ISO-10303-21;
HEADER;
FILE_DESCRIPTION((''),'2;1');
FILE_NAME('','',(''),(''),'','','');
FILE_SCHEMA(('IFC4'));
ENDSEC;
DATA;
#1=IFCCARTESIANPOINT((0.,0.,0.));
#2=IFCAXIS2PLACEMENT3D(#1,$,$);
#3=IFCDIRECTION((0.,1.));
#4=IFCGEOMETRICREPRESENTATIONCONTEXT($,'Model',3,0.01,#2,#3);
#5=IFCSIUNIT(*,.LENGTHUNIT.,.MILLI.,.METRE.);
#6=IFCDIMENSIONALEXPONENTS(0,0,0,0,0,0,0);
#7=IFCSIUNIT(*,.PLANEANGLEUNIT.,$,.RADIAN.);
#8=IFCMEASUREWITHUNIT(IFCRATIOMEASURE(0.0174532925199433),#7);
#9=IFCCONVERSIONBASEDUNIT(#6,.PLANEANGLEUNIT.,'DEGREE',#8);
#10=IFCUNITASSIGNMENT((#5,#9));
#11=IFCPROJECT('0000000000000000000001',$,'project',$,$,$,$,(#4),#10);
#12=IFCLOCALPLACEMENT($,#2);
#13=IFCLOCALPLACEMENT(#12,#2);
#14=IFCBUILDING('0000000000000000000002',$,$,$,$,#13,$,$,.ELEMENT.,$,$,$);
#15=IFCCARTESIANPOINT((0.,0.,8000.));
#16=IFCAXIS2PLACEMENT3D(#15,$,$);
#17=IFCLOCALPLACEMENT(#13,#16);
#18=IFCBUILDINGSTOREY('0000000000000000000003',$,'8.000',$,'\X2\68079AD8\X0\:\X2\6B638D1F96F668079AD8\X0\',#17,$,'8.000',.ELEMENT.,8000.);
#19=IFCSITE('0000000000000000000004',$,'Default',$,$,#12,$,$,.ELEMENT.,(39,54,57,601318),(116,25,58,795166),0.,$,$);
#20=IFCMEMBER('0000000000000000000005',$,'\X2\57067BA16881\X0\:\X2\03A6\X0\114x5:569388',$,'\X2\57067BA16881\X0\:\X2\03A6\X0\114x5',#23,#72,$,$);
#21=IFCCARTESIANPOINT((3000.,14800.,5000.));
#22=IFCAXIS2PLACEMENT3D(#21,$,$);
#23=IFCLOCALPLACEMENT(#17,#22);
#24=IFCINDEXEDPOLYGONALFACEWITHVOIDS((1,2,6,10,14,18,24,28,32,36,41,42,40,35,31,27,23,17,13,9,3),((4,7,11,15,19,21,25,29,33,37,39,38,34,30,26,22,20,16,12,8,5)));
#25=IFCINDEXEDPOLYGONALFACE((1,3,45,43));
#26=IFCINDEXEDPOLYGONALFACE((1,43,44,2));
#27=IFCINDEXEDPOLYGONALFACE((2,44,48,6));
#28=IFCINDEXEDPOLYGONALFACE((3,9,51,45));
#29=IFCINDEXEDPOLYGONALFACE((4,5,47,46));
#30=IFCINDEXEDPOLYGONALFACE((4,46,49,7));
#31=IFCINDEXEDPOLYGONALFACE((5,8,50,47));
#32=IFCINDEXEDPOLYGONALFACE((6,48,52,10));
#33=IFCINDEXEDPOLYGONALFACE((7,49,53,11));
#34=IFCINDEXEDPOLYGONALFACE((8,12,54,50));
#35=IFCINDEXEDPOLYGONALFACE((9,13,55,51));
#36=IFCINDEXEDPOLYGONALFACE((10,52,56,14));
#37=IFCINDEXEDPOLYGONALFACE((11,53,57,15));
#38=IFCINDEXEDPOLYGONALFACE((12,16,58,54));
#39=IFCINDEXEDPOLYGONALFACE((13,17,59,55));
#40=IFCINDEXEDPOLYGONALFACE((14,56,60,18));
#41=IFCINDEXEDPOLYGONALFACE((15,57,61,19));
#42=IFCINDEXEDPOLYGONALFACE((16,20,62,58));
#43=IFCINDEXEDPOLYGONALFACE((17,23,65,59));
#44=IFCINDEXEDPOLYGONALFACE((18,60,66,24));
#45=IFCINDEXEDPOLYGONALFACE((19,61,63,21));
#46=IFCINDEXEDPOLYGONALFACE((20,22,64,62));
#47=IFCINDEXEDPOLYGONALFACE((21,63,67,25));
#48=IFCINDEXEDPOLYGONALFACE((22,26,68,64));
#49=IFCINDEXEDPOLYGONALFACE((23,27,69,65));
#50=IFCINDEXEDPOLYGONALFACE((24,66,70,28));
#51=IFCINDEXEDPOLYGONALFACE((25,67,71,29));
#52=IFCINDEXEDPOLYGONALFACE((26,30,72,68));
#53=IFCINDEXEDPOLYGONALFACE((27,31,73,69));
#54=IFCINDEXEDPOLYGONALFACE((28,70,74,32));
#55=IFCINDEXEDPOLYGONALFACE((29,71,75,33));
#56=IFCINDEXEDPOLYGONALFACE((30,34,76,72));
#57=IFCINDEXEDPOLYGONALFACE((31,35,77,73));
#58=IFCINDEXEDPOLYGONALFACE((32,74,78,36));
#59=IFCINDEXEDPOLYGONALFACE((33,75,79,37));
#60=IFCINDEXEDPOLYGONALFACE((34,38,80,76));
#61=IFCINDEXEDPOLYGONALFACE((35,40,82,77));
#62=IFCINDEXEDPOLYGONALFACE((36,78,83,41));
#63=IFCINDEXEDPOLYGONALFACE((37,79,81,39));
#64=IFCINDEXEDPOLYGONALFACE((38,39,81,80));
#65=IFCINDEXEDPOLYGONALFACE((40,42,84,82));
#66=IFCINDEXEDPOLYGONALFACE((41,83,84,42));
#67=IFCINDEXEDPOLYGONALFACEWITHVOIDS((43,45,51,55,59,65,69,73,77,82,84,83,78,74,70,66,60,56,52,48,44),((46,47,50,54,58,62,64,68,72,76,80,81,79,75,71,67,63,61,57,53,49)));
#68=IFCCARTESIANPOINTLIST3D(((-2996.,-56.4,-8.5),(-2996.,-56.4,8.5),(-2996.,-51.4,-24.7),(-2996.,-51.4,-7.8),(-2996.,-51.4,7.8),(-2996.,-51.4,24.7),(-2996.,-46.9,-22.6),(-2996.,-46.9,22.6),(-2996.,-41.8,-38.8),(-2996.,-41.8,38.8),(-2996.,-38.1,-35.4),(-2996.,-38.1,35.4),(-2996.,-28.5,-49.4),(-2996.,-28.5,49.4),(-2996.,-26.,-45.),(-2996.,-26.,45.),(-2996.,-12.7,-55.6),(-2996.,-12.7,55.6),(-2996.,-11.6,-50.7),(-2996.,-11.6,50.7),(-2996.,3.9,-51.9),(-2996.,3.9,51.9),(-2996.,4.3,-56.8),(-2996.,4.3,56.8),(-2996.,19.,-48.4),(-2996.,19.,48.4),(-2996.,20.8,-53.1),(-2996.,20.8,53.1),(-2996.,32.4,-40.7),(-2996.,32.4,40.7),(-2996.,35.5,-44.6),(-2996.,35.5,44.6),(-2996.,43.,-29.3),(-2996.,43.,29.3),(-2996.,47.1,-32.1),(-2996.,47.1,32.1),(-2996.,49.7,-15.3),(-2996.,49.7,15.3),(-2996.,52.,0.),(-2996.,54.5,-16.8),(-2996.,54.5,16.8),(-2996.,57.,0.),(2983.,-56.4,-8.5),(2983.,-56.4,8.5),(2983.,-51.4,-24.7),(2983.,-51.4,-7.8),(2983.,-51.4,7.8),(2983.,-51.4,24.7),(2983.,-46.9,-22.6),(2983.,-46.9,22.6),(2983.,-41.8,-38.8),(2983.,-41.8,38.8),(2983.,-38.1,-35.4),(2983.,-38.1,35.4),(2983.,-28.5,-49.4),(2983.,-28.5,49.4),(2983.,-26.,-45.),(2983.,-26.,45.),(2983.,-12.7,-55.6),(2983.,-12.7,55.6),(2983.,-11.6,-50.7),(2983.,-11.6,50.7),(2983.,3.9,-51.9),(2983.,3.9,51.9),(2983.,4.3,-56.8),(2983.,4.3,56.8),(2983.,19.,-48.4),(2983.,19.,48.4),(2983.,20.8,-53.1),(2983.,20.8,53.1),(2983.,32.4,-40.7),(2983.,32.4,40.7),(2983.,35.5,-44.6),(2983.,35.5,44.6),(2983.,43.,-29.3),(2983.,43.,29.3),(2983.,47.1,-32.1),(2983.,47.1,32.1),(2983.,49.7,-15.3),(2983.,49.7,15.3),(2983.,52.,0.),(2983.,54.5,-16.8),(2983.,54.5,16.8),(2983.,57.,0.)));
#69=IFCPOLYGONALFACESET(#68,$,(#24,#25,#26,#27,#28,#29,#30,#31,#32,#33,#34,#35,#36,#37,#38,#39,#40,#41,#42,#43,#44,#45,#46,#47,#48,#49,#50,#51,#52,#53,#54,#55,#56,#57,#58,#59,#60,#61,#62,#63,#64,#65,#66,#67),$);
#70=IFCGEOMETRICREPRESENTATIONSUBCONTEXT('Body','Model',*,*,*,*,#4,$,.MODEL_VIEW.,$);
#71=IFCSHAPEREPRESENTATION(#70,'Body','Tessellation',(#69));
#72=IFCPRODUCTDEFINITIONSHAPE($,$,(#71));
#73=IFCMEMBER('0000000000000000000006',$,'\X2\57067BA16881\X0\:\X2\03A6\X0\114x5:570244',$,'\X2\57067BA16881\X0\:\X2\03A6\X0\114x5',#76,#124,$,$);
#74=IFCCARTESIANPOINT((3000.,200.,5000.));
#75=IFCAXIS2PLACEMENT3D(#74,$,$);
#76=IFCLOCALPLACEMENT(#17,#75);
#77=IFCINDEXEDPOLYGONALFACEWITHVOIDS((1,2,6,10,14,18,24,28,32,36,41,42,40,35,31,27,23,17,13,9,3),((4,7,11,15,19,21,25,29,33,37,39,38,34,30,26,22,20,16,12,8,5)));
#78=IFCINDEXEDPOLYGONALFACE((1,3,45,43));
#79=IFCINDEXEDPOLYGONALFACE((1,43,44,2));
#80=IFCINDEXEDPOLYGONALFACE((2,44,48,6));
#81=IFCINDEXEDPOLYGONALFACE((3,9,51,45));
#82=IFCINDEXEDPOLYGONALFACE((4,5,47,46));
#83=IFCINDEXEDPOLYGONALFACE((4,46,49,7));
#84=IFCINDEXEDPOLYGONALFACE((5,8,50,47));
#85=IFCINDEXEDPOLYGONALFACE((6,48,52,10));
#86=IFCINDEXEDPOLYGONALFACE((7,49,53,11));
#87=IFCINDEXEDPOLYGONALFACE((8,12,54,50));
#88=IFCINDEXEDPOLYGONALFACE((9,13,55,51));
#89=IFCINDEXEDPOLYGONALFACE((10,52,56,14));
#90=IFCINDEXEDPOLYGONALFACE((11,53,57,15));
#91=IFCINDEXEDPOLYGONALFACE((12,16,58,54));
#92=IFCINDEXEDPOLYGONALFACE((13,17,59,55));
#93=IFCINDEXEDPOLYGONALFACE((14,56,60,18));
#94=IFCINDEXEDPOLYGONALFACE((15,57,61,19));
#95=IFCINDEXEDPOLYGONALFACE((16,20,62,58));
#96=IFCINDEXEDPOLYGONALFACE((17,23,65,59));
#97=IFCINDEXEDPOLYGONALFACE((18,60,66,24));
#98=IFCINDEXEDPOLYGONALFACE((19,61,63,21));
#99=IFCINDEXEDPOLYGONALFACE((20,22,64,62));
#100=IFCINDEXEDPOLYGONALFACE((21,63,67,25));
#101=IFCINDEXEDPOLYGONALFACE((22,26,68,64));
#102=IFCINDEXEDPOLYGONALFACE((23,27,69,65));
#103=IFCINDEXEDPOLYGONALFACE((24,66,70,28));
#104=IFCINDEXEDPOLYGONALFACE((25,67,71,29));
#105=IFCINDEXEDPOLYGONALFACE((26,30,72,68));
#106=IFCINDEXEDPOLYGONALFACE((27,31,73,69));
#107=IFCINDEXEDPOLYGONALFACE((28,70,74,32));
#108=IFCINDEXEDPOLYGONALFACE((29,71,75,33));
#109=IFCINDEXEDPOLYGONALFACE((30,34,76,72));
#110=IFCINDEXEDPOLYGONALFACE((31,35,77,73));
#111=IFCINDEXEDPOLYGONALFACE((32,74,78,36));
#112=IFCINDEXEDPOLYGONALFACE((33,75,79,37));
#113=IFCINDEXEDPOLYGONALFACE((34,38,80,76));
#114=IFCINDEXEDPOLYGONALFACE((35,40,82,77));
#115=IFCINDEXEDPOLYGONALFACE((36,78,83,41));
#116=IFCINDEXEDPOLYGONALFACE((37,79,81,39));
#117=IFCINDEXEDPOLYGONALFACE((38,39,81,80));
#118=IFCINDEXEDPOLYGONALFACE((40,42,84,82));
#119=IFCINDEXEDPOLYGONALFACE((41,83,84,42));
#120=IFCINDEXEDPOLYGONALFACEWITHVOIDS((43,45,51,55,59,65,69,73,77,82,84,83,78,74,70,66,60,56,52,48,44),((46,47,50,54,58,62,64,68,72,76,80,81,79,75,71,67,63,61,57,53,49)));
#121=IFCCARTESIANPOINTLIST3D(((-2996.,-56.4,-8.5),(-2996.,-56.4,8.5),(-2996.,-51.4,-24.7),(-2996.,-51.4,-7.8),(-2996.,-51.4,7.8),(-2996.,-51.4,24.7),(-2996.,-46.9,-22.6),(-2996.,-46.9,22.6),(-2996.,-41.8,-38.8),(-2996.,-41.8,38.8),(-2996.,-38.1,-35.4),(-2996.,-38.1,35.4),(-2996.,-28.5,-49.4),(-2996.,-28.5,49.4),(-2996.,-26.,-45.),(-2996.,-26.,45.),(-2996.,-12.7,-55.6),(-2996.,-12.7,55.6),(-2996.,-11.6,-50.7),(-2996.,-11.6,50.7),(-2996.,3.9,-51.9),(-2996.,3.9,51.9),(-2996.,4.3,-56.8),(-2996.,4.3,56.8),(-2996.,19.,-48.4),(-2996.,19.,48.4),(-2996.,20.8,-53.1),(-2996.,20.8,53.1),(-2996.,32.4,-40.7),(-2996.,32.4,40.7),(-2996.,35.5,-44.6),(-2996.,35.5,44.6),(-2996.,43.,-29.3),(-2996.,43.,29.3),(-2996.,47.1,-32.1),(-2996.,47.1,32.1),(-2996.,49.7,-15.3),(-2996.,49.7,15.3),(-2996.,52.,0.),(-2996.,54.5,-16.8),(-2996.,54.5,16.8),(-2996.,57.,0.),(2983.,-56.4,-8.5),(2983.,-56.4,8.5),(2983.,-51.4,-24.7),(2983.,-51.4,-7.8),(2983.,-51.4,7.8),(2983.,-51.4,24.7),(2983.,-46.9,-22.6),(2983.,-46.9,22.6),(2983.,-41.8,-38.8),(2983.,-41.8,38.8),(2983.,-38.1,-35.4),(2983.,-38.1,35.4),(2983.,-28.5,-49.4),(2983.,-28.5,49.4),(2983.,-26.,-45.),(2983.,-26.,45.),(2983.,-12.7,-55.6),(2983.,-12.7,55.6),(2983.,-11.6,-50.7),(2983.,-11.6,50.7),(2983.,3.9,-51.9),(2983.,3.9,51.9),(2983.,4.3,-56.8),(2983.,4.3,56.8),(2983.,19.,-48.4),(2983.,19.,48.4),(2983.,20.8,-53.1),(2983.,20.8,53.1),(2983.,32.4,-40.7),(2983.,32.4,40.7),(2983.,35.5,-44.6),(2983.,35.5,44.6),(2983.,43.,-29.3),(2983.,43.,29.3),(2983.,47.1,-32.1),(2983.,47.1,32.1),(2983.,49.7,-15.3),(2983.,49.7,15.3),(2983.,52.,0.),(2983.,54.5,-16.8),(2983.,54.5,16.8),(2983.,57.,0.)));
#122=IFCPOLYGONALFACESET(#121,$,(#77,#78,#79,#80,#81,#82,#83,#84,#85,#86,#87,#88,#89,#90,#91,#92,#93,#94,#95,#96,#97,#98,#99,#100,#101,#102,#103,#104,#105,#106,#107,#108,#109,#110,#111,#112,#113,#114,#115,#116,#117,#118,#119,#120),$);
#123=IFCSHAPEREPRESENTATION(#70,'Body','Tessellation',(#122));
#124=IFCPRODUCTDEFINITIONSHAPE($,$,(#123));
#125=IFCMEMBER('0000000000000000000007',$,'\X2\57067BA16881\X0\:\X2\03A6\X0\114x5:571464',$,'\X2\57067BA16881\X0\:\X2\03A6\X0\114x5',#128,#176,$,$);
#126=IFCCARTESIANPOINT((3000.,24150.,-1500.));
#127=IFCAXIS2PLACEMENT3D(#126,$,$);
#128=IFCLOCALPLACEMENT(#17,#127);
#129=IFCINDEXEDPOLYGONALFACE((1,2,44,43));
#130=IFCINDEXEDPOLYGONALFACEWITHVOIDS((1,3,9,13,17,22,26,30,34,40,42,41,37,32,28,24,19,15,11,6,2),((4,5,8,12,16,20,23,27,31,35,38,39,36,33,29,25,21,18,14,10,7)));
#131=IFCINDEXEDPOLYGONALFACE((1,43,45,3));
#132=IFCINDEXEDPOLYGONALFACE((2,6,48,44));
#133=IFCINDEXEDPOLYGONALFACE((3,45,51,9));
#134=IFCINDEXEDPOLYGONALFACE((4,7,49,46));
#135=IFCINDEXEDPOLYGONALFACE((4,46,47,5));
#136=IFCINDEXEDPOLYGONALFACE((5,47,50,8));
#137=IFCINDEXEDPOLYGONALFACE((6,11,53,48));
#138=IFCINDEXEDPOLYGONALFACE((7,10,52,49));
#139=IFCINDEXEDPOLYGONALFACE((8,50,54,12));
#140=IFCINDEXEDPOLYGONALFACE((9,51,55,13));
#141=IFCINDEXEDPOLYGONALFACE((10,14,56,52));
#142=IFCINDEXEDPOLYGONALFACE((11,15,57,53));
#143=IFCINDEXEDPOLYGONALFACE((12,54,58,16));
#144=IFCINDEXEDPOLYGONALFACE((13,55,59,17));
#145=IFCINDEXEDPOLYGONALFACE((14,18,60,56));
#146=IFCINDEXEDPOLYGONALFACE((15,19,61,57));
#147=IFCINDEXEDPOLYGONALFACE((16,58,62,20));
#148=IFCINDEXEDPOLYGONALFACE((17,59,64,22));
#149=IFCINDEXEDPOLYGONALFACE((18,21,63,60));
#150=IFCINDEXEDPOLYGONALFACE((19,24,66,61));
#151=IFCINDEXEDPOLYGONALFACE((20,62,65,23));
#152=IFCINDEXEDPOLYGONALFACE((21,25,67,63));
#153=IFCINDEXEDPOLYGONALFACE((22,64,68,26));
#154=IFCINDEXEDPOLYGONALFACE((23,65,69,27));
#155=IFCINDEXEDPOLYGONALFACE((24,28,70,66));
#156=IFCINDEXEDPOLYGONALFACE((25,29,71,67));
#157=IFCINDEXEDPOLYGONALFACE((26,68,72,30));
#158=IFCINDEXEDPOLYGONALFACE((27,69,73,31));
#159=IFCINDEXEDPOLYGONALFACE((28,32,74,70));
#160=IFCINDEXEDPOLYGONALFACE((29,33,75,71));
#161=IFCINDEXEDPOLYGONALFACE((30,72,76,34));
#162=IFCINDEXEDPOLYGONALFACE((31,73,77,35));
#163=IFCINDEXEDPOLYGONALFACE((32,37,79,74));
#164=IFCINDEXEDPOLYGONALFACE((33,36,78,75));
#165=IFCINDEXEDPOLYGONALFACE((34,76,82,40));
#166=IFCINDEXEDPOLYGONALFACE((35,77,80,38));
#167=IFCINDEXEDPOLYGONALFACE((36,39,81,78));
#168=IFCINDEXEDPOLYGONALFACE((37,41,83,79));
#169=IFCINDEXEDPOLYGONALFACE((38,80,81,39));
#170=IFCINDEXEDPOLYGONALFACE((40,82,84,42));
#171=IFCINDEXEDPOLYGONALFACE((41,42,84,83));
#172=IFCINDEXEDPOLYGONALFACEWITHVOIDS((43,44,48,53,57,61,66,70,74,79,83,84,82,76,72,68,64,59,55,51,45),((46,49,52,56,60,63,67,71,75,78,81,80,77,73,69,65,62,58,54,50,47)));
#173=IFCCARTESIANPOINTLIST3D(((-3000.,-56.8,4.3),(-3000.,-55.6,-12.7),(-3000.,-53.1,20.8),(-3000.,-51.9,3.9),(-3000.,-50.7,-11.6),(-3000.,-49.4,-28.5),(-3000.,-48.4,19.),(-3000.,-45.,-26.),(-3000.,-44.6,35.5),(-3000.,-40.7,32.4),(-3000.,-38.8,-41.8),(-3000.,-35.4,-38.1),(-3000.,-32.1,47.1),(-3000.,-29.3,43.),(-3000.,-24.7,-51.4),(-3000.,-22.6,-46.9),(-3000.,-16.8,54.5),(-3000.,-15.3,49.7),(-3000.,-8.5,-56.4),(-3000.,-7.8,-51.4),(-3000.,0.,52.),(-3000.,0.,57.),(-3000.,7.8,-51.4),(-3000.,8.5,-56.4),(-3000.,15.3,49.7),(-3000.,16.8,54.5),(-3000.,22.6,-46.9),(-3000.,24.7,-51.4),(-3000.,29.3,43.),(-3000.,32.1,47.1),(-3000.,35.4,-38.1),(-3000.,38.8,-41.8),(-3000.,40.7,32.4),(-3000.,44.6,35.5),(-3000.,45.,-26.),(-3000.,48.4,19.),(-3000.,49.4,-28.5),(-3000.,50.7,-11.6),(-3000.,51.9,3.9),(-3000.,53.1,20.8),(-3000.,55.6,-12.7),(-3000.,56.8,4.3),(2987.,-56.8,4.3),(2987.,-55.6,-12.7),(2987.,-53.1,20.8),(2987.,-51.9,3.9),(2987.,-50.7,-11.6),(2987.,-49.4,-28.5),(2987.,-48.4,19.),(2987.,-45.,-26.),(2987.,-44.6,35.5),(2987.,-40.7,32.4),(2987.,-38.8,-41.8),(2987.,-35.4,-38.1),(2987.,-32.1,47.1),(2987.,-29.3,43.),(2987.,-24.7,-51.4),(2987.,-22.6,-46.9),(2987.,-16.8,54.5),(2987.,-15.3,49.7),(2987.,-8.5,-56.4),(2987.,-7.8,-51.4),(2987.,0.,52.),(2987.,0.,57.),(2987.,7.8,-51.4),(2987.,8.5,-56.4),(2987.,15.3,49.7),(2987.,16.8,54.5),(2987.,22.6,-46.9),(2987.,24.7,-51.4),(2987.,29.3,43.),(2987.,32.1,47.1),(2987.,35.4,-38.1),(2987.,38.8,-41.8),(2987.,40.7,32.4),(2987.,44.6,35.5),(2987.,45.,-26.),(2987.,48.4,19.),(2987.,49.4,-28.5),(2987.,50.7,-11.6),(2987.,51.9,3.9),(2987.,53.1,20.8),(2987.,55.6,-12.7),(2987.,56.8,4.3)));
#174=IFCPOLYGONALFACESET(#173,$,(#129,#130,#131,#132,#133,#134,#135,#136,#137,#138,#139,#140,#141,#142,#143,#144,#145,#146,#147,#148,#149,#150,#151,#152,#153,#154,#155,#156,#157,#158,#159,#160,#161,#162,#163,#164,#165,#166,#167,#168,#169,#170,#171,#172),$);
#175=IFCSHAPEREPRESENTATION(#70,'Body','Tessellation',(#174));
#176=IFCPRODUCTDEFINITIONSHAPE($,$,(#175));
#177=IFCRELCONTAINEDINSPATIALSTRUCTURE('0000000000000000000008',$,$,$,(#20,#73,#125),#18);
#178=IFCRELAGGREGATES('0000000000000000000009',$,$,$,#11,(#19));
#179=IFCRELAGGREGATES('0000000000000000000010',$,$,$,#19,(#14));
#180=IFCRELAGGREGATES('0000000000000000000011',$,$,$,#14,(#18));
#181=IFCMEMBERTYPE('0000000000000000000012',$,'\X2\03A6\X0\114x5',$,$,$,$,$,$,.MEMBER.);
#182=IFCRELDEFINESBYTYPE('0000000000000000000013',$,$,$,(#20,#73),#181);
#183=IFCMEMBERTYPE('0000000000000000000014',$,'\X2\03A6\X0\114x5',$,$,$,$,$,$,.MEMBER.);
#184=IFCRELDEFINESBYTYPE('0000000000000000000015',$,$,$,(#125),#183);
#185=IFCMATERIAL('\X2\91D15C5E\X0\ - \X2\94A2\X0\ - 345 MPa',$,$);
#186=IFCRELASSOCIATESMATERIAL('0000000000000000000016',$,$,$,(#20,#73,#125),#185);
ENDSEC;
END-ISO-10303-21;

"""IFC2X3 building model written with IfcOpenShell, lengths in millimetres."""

from ifc_helpers import new_model, entity, si_unit, converted_unit, direction, frame, frame_2d, origin, place, context, subcontext, project, spatial, hollow_circle, extrude, source, transform, mapped, material, type_object, type_shapes, element, save


model = new_model("IFC2X3")

# Units and contexts
model_context = context("Model", 3, precision=0.01, world=origin(), true_north=direction((0.0, 1.0)))
body_context = subcontext(model_context, "Body", "Model", "MODEL_VIEW")
ifc_project = project(units=[si_unit("LENGTHUNIT", "METRE", prefix="MILLI"), converted_unit("PLANEANGLEUNIT", "DEGREE", entity("IfcRatioMeasure", 0.0174532925199433), si_unit("PLANEANGLEUNIT", "RADIAN"), dimensions=[0, 0, 0, 0, 0, 0, 0])], contexts=[model_context])

# Site, building, storey
site_placement = place(None, origin())
site = spatial("IfcSite", under=ifc_project, at=site_placement, Name="Default", CompositionType="ELEMENT", RefLatitude=(39, 54, 57, 601318), RefLongitude=(116, 25, 58, 795166), RefElevation=0.0)
building_placement = place(site_placement, origin())
building = spatial("IfcBuilding", under=site, at=building_placement, CompositionType="ELEMENT")
storey_placement = place(building_placement, frame((0.0, 0.0, 8000.0)))
storey = spatial("IfcBuildingStorey", under=building, at=storey_placement, Name="8.000", ObjectType="标高:正负零标高", LongName="8.000", CompositionType="ELEMENT", Elevation=8000.0)

# Shared definitions
ifc_material_1 = material(Name="金属 - 钢 - 345 MPa")

# Members
member_type_1 = type_object("IfcMemberType", Name="Φ114x5", PredefinedType="MEMBER")
shared_shape_1 = source(origin(), body_context, "Body", "SweptSolid", [
    extrude(hollow_circle(Radius=57.0, WallThickness=5.0, at=frame_2d((0.0, 0.0), x_axis=(1.0, 0.0))), frame((-2996.0, 0.0, 0.0), z_axis=(1.0, 0.0, 0.0), x_axis=(0.0, 1.0, 0.0)), (0.0, 0.0, 1.0), 5979.0),
])
type_shapes(member_type_1, [shared_shape_1])
for number, where, name in (
    (1, (3000.0, 14800.0, 5000.0), "圆管梁:Φ114x5:569388"),
    (2, (3000.0, 200.0, 5000.0), "圆管梁:Φ114x5:570244"),
):
    element("IfcMember", number, at=place(storey_placement, frame(where)), inside=storey, type_object=member_type_1, material=ifc_material_1, Name=name, ObjectType="圆管梁:Φ114x5", context=body_context, shape_type="MappedRepresentation", body=[
        mapped(shared_shape_1, transform((0.0, 0.0, 0.0), scale=1.0)),
    ])
member_type_2 = type_object("IfcMemberType", Name="Φ114x5", PredefinedType="MEMBER")
shared_shape_2 = source(origin(), body_context, "Body", "SweptSolid", [
    extrude(hollow_circle(Radius=57.0, WallThickness=5.0, at=frame_2d((0.0, 0.0), x_axis=(1.0, 0.0))), frame((-3000.0, 0.0, 0.0), z_axis=(1.0, 0.0, 0.0), x_axis=(0.0, 0.0, 1.0)), (0.0, 0.0, 1.0), 5987.0),
])
type_shapes(member_type_2, [shared_shape_2])
for number, where, name in (
    (3, (3000.0, 24150.0, -1500.0), "圆管梁:Φ114x5:571464"),
):
    element("IfcMember", number, at=place(storey_placement, frame(where)), inside=storey, type_object=member_type_2, material=ifc_material_1, Name=name, ObjectType="圆管梁:Φ114x5", context=body_context, shape_type="MappedRepresentation", body=[
        mapped(shared_shape_2, transform((0.0, 0.0, 0.0), scale=1.0)),
    ])

save(model, "model.ifc")
